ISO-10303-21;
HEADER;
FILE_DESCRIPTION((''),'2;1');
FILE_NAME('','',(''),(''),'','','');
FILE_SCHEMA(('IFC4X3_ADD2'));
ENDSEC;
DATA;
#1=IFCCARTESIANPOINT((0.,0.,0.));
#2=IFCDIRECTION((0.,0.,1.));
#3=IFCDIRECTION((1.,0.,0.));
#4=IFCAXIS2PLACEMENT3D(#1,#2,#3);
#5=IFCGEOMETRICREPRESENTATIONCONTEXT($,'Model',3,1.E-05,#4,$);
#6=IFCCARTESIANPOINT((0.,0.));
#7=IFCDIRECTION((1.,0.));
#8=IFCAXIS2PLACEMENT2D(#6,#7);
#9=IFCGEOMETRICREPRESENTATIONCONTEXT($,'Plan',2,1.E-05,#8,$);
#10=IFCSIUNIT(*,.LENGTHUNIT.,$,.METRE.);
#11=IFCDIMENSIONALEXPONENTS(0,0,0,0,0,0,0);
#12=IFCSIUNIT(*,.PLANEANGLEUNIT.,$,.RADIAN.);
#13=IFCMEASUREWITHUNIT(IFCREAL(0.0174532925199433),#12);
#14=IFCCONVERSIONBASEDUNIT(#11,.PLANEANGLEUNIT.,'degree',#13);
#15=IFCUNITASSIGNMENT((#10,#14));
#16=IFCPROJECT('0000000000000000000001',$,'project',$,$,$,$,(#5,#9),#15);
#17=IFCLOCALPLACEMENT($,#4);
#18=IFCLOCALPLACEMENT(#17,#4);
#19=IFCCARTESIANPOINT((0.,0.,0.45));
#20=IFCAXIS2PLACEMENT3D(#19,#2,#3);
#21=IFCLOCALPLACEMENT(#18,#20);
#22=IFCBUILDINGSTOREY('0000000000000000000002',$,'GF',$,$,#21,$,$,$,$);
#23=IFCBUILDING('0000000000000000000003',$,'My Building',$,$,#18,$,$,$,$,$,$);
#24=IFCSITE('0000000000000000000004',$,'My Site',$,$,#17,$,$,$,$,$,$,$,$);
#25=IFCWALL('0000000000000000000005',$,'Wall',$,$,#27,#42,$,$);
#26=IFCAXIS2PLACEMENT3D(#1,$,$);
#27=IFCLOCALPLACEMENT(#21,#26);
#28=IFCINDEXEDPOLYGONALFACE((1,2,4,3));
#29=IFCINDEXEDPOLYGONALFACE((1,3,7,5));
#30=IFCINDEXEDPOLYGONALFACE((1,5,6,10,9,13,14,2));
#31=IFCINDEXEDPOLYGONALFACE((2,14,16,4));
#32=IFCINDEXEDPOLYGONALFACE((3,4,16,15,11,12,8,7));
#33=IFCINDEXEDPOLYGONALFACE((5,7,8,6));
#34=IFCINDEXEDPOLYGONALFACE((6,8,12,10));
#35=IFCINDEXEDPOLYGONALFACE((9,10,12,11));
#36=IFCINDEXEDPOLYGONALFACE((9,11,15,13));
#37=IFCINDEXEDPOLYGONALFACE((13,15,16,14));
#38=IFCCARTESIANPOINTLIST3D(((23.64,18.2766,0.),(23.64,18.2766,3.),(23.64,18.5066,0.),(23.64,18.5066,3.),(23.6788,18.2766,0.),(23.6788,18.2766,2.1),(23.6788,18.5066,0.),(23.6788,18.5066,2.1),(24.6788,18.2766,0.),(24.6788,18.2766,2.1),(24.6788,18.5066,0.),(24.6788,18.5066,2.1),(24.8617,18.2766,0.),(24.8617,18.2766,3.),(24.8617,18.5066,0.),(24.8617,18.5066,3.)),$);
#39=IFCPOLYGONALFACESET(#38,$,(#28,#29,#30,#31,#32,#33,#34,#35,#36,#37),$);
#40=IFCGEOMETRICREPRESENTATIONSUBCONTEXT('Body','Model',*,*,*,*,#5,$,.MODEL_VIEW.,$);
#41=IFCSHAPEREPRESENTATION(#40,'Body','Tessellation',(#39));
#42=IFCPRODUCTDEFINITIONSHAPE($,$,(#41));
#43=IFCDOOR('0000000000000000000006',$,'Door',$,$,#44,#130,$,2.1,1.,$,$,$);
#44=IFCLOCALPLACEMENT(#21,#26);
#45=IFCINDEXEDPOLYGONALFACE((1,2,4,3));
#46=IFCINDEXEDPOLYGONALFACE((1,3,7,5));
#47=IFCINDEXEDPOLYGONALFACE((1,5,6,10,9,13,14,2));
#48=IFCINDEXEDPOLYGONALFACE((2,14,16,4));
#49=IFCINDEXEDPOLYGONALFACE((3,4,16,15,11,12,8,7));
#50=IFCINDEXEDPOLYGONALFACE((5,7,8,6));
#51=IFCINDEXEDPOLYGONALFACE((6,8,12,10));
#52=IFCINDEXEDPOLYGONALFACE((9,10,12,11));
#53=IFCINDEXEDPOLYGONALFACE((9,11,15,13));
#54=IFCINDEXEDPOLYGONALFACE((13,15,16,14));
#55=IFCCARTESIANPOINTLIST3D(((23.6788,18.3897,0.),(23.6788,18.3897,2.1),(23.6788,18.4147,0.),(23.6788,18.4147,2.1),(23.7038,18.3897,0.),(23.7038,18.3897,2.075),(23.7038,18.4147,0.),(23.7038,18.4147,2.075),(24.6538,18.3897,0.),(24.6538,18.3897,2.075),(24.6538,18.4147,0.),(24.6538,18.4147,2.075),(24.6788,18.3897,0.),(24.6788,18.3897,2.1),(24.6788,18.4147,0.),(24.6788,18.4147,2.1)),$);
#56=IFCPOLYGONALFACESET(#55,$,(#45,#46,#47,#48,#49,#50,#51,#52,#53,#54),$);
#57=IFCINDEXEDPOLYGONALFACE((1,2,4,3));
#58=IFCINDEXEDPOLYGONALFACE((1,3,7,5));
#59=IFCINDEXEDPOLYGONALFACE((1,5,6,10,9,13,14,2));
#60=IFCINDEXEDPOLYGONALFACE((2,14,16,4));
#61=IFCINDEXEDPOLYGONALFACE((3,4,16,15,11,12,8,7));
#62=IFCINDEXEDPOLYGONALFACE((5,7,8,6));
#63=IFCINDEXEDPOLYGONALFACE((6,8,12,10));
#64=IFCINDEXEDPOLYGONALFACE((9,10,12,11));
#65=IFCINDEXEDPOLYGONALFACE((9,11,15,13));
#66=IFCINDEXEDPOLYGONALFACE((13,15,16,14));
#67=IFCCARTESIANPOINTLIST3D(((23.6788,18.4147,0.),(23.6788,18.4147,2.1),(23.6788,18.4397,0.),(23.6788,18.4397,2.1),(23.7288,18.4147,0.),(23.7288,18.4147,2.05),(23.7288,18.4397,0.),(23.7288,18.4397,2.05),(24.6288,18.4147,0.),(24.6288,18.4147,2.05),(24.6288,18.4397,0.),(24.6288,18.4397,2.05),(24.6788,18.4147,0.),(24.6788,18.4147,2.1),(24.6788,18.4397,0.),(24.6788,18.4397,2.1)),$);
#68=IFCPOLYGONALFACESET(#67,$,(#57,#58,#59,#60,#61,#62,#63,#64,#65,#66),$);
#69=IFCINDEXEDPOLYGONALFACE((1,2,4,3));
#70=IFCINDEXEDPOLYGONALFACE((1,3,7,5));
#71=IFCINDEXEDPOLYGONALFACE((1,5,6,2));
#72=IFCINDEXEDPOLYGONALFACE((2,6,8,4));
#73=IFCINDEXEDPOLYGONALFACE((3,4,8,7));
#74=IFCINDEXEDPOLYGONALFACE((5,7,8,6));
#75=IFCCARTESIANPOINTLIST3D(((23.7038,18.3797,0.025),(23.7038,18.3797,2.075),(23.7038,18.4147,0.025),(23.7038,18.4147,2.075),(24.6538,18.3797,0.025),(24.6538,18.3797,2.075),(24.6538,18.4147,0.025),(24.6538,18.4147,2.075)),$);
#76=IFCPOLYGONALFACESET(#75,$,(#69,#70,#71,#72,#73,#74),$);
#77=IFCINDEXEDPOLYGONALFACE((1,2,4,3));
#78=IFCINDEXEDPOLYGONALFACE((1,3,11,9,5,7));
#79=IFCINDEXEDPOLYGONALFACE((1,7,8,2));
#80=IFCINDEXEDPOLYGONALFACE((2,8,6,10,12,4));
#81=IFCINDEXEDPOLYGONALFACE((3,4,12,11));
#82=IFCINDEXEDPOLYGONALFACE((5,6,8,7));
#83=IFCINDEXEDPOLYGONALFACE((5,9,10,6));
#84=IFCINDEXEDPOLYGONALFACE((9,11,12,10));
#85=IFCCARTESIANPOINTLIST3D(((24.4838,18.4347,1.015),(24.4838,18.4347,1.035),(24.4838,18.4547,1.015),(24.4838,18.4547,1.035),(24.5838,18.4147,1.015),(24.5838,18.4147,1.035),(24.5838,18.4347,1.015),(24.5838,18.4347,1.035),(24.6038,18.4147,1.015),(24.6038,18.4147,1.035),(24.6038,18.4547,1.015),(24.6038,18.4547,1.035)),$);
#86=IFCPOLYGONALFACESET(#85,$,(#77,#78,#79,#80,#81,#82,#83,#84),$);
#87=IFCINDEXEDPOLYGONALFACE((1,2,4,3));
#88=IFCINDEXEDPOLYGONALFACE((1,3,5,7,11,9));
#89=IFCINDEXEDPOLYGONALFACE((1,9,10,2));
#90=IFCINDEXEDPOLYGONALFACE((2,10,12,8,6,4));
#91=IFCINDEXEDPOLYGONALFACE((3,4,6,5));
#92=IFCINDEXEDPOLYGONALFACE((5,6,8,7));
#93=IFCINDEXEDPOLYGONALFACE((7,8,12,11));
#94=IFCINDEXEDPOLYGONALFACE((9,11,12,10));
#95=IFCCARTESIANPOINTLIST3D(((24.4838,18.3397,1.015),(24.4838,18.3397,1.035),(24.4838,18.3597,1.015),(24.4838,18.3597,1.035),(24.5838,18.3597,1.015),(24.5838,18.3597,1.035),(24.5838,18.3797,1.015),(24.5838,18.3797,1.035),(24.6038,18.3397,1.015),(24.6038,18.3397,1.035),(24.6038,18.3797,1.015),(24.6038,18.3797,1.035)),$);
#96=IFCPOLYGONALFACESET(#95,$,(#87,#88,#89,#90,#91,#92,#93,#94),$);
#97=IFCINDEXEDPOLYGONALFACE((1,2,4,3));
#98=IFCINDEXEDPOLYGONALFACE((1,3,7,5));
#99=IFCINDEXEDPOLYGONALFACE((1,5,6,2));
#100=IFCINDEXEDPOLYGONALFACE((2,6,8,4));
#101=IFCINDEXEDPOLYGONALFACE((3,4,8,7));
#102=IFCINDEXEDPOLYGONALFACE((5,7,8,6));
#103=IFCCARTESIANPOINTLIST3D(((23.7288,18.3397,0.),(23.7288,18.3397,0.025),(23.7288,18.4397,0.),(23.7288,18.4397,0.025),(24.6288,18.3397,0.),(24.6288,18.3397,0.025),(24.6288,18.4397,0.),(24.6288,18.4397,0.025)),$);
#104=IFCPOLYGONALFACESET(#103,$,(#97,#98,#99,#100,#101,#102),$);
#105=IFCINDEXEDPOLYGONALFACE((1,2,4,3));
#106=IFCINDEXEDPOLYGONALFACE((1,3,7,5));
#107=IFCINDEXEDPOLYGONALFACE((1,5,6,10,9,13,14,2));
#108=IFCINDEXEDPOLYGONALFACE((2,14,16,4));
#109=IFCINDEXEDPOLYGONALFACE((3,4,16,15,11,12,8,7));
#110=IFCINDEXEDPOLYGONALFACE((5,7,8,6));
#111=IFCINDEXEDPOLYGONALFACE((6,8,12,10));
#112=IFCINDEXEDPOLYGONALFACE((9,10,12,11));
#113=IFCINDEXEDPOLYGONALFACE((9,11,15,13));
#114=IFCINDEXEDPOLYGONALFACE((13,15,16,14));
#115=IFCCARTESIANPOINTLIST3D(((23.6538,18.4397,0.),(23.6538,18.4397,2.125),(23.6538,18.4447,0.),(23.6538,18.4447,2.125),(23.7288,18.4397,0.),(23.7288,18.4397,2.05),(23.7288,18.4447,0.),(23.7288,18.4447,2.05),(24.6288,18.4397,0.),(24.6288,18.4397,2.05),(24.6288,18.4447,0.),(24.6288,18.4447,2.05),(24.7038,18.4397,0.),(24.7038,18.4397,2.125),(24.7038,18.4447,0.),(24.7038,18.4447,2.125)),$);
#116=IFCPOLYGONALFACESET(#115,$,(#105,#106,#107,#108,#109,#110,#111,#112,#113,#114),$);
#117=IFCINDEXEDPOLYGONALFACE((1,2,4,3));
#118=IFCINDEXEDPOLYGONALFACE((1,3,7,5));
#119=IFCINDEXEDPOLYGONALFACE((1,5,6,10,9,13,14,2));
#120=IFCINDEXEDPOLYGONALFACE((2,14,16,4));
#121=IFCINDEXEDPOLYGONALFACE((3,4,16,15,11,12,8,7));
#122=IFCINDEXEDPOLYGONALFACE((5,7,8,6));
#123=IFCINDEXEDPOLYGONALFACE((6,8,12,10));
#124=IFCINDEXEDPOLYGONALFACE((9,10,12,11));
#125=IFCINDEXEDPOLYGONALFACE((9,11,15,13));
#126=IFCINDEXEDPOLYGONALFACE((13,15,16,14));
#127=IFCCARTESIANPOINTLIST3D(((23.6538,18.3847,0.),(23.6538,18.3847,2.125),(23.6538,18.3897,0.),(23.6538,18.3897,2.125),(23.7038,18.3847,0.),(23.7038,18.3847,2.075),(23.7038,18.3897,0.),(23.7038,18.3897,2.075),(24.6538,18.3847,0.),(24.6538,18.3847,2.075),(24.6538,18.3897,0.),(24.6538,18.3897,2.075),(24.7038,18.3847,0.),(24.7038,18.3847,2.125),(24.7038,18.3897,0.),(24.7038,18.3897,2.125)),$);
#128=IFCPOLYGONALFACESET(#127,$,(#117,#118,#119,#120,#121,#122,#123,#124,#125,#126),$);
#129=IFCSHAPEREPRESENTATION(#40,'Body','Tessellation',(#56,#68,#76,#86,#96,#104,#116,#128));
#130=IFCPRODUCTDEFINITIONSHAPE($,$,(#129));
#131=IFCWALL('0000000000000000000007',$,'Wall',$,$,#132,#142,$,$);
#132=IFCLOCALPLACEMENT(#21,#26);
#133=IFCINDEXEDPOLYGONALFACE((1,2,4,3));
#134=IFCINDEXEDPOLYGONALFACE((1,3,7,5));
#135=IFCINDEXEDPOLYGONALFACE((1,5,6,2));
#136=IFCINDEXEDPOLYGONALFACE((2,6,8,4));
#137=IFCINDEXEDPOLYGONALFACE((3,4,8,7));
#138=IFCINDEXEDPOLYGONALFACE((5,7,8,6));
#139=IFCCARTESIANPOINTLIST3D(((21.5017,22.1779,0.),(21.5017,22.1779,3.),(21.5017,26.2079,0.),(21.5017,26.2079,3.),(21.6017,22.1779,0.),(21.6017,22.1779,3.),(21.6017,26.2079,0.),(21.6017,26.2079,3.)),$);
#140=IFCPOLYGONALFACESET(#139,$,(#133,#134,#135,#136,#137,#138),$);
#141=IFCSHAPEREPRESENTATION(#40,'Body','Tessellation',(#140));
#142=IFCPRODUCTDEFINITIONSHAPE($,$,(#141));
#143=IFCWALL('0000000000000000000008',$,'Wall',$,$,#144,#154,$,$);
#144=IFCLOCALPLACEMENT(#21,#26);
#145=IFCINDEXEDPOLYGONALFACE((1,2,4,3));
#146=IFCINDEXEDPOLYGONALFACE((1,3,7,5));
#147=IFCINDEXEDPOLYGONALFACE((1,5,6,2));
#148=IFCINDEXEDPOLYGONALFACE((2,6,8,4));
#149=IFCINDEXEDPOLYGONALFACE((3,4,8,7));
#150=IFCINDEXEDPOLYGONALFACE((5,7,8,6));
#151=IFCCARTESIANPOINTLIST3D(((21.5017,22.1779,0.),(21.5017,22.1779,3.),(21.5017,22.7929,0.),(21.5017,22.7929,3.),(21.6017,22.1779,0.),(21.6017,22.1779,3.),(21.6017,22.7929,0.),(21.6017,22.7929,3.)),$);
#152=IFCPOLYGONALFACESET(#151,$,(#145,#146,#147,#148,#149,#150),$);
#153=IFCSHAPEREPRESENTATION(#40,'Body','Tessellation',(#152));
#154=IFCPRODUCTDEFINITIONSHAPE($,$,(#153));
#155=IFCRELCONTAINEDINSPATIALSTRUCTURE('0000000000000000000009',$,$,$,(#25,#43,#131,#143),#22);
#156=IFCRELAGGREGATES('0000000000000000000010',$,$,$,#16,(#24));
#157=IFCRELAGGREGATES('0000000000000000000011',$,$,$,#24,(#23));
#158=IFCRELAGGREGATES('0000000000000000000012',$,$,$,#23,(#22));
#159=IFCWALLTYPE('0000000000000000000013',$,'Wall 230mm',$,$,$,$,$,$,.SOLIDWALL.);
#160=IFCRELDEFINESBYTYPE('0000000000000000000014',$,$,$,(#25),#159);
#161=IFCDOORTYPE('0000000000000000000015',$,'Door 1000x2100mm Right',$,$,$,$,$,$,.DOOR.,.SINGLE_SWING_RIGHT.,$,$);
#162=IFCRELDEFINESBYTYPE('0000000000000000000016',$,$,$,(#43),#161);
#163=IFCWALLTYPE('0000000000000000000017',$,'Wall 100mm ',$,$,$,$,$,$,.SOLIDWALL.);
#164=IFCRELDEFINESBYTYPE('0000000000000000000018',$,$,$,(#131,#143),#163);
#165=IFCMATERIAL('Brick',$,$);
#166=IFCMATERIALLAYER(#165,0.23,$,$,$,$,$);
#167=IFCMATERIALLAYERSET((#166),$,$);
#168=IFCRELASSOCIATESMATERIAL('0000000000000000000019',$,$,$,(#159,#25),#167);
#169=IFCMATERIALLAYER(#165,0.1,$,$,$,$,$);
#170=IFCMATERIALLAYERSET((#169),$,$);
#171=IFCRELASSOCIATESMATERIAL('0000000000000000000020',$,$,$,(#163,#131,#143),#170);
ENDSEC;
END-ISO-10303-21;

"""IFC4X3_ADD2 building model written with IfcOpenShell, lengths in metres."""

from ifc_helpers import new_model, entity, si_unit, converted_unit, frame, origin_with_axes, origin_2d_with_axis, place, context, subcontext, project, spatial, line, indexed_curve, outline, extrude, shape, source, transform, mapped, material, layer, layer_set, layer_usage, type_object, type_shapes, element, fill, save


model = new_model("IFC4X3_ADD2")

# Units and contexts
model_context = context("Model", 3, precision=1e-05, world=origin_with_axes())
plan_context = context("Plan", 2, precision=1e-05, world=origin_2d_with_axis())
body_context_1 = subcontext(model_context, "Body", "Model", "MODEL_VIEW")
body_context_2 = subcontext(plan_context, "Body", "Plan", "PLAN_VIEW")
ifc_project = project(units=[si_unit("LENGTHUNIT", "METRE"), converted_unit("PLANEANGLEUNIT", "degree", entity("IfcReal", 0.0174532925199433), si_unit("PLANEANGLEUNIT", "RADIAN"), dimensions=[0, 0, 0, 0, 0, 0, 0])], contexts=[model_context, plan_context])

# Site, building, storey
site_placement = place(None, origin_with_axes())
site = spatial("IfcSite", under=ifc_project, at=site_placement, Name="My Site")
building_placement = place(site_placement, origin_with_axes())
building = spatial("IfcBuilding", under=site, at=building_placement, Name="My Building")
storey_placement = place(building_placement, frame((0.0, 0.0, 0.45), z_axis=(0.0, 0.0, 1.0), x_axis=(1.0, 0.0, 0.0)))
storey = spatial("IfcBuildingStorey", under=building, at=storey_placement, Name="GF")

# Shared definitions
ifc_material = material(Name="Brick")
ifc_layer_1 = layer(ifc_material, 0.23)
ifc_layer_set_1 = layer_set([ifc_layer_1])
wall_type_1 = type_object("IfcWallType", Name="Wall 230mm", PredefinedType="SOLIDWALL", material=ifc_layer_set_1)

# Shared definitions
shared_shape_1 = source(origin_with_axes(), body_context_1, "Body", "SweptSolid", [
    extrude(outline(indexed_curve([(0.0, 0.0), (1.0, 0.0), (1.0, 2.1), (0.0, 2.1)], segments=[line(1, 2, 3, 4, 1)])), frame((0.0, -0.6, 0.0), z_axis=(0.0, -1.0, 0.0), x_axis=(1.0, 0.0, 0.0)), (0.0, 0.0, -1.0), 1.2),
])
door_type_1 = type_object("IfcDoorType", Name="Door 1000x2100mm Right", OperationType="SINGLE_SWING_RIGHT", PredefinedType="DOOR")
shared_shape_2 = source(origin_with_axes(), body_context_1, "Body", "SweptSolid", [
    extrude(outline(indexed_curve([(0.0, 0.0), (0.0, 2.1), (1.0, 2.1), (1.0, 0.0), (0.975, 0.0), (0.975, 2.075), (0.025, 2.075), (0.025, 0.0)], segments=[line(1, 2, 3, 4, 5, 6, 7, 8, 1)])), frame((0.0, 0.025, 0.0), z_axis=(0.0, -1.0, 0.0), x_axis=(1.0, 0.0, 0.0)), (0.0, 0.0, -1.0), 0.025),
    extrude(outline(indexed_curve([(0.0, 0.0), (0.0, 2.1), (1.0, 2.1), (1.0, 0.0), (0.95, 0.0), (0.95, 2.05), (0.05, 2.05), (0.05, 0.0)], segments=[line(1, 2, 3, 4, 5, 6, 7, 8, 1)])), frame((0.0, 0.0, 0.0), z_axis=(0.0, -1.0, 0.0), x_axis=(1.0, 0.0, 0.0)), (0.0, 0.0, -1.0), 0.025),
    extrude(outline(indexed_curve([(0.0, 0.0), (0.95, 0.0), (0.95, 0.035), (0.0, 0.035)], segments=[line(1, 2, 3, 4, 1)])), frame((0.025, 0.025, 0.025), z_axis=(0.0, 0.0, 1.0), x_axis=(1.0, 0.0, 0.0)), (0.0, 0.0, 1.0), 2.05),
    extrude(outline(indexed_curve([(0.0, 0.0), (0.0, -0.04), (0.12, -0.04), (0.12, -0.02), (0.02, -0.02), (0.02, 0.0)], segments=[line(1, 2, 3, 4, 5, 6, 1)])), frame((0.075, 0.025, 1.015), z_axis=(0.0, 0.0, 1.0), x_axis=(1.0, 0.0, 0.0)), (0.0, 0.0, 1.0), 0.02),
    extrude(outline(indexed_curve([(0.0, 0.0), (0.0, 0.04), (0.12, 0.04), (0.12, 0.02), (0.02, 0.02), (0.02, 0.0)], segments=[line(1, 2, 3, 4, 5, 6, 1)])), frame((0.075, 0.06, 1.015), z_axis=(0.0, 0.0, 1.0), x_axis=(1.0, 0.0, 0.0)), (0.0, 0.0, 1.0), 0.02),
    extrude(outline(indexed_curve([(0.0, 0.0), (0.9, 0.0), (0.9, 0.1), (0.0, 0.1)], segments=[line(1, 2, 3, 4, 1)])), frame((0.05, 0.0, 0.0), z_axis=(0.0, 0.0, 1.0), x_axis=(1.0, 0.0, 0.0)), (0.0, 0.0, 1.0), 0.025),
    extrude(outline(indexed_curve([(0.0, 0.0), (0.0, 2.125), (1.05, 2.125), (1.05, 0.0), (0.975, 0.0), (0.975, 2.05), (0.075, 2.05), (0.075, 0.0)], segments=[line(1, 2, 3, 4, 5, 6, 7, 8, 1)])), frame((-0.025, -0.005, 0.0), z_axis=(0.0, -1.0, 0.0), x_axis=(1.0, 0.0, 0.0)), (0.0, 0.0, -1.0), 0.005),
    extrude(outline(indexed_curve([(0.0, 0.0), (0.0, 2.125), (1.05, 2.125), (1.05, 0.0), (1.0, 0.0), (1.0, 2.075), (0.05, 2.075), (0.05, 0.0)], segments=[line(1, 2, 3, 4, 5, 6, 7, 8, 1)])), frame((-0.025, 0.05, 0.0), z_axis=(0.0, -1.0, 0.0), x_axis=(1.0, 0.0, 0.0)), (0.0, 0.0, -1.0), 0.005),
])
shared_shape_3 = source(origin_with_axes(), body_context_2, "Body", "Curve2D", [
    entity("IfcIndexedPolyCurve", entity("IfcCartesianPointList2D", [[0.0, 0.0], [0.0, 0.05], [0.025, 0.05], [0.025, 0.025], [0.05, 0.025], [0.05, 0.0]]), [entity("IfcLineIndex", [1, 2, 3, 4, 5, 6, 1])]),
    entity("IfcIndexedPolyCurve", entity("IfcCartesianPointList2D", [[1.0, 0.0], [1.0, 0.05], [0.975, 0.05], [0.975, 0.025], [0.95, 0.025], [0.95, 0.0]]), [entity("IfcLineIndex", [1, 2, 3, 4, 5, 6, 1])]),
    entity("IfcTrimmedCurve", entity("IfcEllipse", entity("IfcAxis2Placement2D", entity("IfcCartesianPoint", [0.94, 0.05]), entity("IfcDirection", [1.0, 0.0])), 0.915, 0.95), [entity("IfcCartesianPoint", [0.94, 1.0])], [entity("IfcCartesianPoint", [0.025, 0.05])], True, "CARTESIAN"),
    entity("IfcIndexedPolyCurve", entity("IfcCartesianPointList2D", [[0.975, 0.05], [0.94, 0.05], [0.94, 1.0], [0.975, 1.0]]), [entity("IfcLineIndex", [1, 2, 3, 4, 1])]),
])
type_shapes(door_type_1, [shared_shape_2, shared_shape_3])

# Wall, opening, door
ifc_layer_usage_1 = layer_usage(ifc_layer_set_1, "AXIS2", "POSITIVE", 0.0)
wall_1_placement = place(storey_placement, frame((23.64, 18.2766, 0.0), z_axis=(0.0, 0.0, 1.0), x_axis=(1.0, 0.0, 0.0)))
wall_1 = element("IfcWall", 1, at=wall_1_placement, inside=storey, type_object=wall_type_1, material=ifc_layer_usage_1, Name="Wall", context=body_context_1, shape_type="SweptSolid", body=[
    extrude(outline(indexed_curve([(0.0, 0.0), (0.0, 0.23), (1.2216, 0.23), (1.2216, 0.0), (0.0, 0.0)], self_intersect=False)), origin_with_axes(), (0.0, 0.0, 1.0), 3.0),
])
opening_1_placement = place(wall_1_placement, frame((1.0387, 0.1631, 0.0), z_axis=(0.0, 0.0, 1.0), x_axis=(-1.0, 0.0, 0.0)))
opening_1 = element("IfcOpeningElement", 2, at=opening_1_placement, cuts=wall_1, PredefinedType="OPENING", context=body_context_1, shape_type="MappedRepresentation", body=[
    mapped(shared_shape_1, transform((0.0, 0.0, 0.0), x_axis=(1.0, 0.0, 0.0), y_axis=(0.0, 1.0, 0.0), z_axis=(0.0, 0.0, 1.0), scale=1.0)),
])
door_1_placement = place(opening_1_placement, origin_with_axes())
door_1 = element("IfcDoor", 3, at=door_1_placement, inside=storey, type_object=door_type_1, Name="Door", OverallHeight=2.1, OverallWidth=1.0, shapes=[
    shape(body_context_1, "Body", "MappedRepresentation", [mapped(shared_shape_2, transform((0.0, 0.0, 0.0), x_axis=(1.0, 0.0, 0.0), y_axis=(0.0, 1.0, 0.0), z_axis=(0.0, 0.0, 1.0), scale=1.0))]),
    shape(body_context_2, "Body", "MappedRepresentation", [mapped(shared_shape_3, transform((0.0, 0.0, 0.0), x_axis=(1.0, 0.0, 0.0), y_axis=(0.0, 1.0, 0.0), z_axis=(0.0, 0.0, 1.0), scale=1.0))]),
])
fill(opening_1, door_1)

# Walls
ifc_layer_2 = layer(ifc_material, 0.1)
ifc_layer_set_2 = layer_set([ifc_layer_2])
ifc_layer_usage_2 = layer_usage(ifc_layer_set_2, "AXIS2", "POSITIVE", 0.0)
wall_type_2 = type_object("IfcWallType", Name="Wall 100mm ", PredefinedType="SOLIDWALL", material=ifc_layer_set_2)
wall_2_placement = place(storey_placement, frame((21.6017, 22.1779, 0.0), z_axis=(0.0, 0.0, 1.0), x_axis=(0.0, 1.0, 0.0)))
element("IfcWall", 4, at=wall_2_placement, inside=storey, type_object=wall_type_2, material=ifc_layer_usage_2, Name="Wall", context=body_context_1, shape_type="SweptSolid", body=[
    extrude(outline(indexed_curve([(0.0, 0.0), (0.0, 0.1), (4.03, 0.1), (4.03, 0.0), (0.0, 0.0)], self_intersect=False)), origin_with_axes(), (0.0, 0.0, 1.0), 3.0),
])
ifc_layer_usage_3 = layer_usage(ifc_layer_set_2, "AXIS2", "POSITIVE", 0.0)
wall_3_placement = place(storey_placement, frame((21.6017, 22.1779, 0.0), z_axis=(0.0, 0.0, 1.0), x_axis=(0.0, 1.0, 0.0)))
element("IfcWall", 5, at=wall_3_placement, inside=storey, type_object=wall_type_2, material=ifc_layer_usage_3, Name="Wall", context=body_context_1, shape_type="SweptSolid", body=[
    extrude(outline(indexed_curve([(0.0, 0.0), (0.0, 0.1), (0.615, 0.1), (0.615, 0.0), (0.0, 0.0)], self_intersect=False)), origin_with_axes(), (0.0, 0.0, 1.0), 3.0),
])

save(model, "model.ifc")
